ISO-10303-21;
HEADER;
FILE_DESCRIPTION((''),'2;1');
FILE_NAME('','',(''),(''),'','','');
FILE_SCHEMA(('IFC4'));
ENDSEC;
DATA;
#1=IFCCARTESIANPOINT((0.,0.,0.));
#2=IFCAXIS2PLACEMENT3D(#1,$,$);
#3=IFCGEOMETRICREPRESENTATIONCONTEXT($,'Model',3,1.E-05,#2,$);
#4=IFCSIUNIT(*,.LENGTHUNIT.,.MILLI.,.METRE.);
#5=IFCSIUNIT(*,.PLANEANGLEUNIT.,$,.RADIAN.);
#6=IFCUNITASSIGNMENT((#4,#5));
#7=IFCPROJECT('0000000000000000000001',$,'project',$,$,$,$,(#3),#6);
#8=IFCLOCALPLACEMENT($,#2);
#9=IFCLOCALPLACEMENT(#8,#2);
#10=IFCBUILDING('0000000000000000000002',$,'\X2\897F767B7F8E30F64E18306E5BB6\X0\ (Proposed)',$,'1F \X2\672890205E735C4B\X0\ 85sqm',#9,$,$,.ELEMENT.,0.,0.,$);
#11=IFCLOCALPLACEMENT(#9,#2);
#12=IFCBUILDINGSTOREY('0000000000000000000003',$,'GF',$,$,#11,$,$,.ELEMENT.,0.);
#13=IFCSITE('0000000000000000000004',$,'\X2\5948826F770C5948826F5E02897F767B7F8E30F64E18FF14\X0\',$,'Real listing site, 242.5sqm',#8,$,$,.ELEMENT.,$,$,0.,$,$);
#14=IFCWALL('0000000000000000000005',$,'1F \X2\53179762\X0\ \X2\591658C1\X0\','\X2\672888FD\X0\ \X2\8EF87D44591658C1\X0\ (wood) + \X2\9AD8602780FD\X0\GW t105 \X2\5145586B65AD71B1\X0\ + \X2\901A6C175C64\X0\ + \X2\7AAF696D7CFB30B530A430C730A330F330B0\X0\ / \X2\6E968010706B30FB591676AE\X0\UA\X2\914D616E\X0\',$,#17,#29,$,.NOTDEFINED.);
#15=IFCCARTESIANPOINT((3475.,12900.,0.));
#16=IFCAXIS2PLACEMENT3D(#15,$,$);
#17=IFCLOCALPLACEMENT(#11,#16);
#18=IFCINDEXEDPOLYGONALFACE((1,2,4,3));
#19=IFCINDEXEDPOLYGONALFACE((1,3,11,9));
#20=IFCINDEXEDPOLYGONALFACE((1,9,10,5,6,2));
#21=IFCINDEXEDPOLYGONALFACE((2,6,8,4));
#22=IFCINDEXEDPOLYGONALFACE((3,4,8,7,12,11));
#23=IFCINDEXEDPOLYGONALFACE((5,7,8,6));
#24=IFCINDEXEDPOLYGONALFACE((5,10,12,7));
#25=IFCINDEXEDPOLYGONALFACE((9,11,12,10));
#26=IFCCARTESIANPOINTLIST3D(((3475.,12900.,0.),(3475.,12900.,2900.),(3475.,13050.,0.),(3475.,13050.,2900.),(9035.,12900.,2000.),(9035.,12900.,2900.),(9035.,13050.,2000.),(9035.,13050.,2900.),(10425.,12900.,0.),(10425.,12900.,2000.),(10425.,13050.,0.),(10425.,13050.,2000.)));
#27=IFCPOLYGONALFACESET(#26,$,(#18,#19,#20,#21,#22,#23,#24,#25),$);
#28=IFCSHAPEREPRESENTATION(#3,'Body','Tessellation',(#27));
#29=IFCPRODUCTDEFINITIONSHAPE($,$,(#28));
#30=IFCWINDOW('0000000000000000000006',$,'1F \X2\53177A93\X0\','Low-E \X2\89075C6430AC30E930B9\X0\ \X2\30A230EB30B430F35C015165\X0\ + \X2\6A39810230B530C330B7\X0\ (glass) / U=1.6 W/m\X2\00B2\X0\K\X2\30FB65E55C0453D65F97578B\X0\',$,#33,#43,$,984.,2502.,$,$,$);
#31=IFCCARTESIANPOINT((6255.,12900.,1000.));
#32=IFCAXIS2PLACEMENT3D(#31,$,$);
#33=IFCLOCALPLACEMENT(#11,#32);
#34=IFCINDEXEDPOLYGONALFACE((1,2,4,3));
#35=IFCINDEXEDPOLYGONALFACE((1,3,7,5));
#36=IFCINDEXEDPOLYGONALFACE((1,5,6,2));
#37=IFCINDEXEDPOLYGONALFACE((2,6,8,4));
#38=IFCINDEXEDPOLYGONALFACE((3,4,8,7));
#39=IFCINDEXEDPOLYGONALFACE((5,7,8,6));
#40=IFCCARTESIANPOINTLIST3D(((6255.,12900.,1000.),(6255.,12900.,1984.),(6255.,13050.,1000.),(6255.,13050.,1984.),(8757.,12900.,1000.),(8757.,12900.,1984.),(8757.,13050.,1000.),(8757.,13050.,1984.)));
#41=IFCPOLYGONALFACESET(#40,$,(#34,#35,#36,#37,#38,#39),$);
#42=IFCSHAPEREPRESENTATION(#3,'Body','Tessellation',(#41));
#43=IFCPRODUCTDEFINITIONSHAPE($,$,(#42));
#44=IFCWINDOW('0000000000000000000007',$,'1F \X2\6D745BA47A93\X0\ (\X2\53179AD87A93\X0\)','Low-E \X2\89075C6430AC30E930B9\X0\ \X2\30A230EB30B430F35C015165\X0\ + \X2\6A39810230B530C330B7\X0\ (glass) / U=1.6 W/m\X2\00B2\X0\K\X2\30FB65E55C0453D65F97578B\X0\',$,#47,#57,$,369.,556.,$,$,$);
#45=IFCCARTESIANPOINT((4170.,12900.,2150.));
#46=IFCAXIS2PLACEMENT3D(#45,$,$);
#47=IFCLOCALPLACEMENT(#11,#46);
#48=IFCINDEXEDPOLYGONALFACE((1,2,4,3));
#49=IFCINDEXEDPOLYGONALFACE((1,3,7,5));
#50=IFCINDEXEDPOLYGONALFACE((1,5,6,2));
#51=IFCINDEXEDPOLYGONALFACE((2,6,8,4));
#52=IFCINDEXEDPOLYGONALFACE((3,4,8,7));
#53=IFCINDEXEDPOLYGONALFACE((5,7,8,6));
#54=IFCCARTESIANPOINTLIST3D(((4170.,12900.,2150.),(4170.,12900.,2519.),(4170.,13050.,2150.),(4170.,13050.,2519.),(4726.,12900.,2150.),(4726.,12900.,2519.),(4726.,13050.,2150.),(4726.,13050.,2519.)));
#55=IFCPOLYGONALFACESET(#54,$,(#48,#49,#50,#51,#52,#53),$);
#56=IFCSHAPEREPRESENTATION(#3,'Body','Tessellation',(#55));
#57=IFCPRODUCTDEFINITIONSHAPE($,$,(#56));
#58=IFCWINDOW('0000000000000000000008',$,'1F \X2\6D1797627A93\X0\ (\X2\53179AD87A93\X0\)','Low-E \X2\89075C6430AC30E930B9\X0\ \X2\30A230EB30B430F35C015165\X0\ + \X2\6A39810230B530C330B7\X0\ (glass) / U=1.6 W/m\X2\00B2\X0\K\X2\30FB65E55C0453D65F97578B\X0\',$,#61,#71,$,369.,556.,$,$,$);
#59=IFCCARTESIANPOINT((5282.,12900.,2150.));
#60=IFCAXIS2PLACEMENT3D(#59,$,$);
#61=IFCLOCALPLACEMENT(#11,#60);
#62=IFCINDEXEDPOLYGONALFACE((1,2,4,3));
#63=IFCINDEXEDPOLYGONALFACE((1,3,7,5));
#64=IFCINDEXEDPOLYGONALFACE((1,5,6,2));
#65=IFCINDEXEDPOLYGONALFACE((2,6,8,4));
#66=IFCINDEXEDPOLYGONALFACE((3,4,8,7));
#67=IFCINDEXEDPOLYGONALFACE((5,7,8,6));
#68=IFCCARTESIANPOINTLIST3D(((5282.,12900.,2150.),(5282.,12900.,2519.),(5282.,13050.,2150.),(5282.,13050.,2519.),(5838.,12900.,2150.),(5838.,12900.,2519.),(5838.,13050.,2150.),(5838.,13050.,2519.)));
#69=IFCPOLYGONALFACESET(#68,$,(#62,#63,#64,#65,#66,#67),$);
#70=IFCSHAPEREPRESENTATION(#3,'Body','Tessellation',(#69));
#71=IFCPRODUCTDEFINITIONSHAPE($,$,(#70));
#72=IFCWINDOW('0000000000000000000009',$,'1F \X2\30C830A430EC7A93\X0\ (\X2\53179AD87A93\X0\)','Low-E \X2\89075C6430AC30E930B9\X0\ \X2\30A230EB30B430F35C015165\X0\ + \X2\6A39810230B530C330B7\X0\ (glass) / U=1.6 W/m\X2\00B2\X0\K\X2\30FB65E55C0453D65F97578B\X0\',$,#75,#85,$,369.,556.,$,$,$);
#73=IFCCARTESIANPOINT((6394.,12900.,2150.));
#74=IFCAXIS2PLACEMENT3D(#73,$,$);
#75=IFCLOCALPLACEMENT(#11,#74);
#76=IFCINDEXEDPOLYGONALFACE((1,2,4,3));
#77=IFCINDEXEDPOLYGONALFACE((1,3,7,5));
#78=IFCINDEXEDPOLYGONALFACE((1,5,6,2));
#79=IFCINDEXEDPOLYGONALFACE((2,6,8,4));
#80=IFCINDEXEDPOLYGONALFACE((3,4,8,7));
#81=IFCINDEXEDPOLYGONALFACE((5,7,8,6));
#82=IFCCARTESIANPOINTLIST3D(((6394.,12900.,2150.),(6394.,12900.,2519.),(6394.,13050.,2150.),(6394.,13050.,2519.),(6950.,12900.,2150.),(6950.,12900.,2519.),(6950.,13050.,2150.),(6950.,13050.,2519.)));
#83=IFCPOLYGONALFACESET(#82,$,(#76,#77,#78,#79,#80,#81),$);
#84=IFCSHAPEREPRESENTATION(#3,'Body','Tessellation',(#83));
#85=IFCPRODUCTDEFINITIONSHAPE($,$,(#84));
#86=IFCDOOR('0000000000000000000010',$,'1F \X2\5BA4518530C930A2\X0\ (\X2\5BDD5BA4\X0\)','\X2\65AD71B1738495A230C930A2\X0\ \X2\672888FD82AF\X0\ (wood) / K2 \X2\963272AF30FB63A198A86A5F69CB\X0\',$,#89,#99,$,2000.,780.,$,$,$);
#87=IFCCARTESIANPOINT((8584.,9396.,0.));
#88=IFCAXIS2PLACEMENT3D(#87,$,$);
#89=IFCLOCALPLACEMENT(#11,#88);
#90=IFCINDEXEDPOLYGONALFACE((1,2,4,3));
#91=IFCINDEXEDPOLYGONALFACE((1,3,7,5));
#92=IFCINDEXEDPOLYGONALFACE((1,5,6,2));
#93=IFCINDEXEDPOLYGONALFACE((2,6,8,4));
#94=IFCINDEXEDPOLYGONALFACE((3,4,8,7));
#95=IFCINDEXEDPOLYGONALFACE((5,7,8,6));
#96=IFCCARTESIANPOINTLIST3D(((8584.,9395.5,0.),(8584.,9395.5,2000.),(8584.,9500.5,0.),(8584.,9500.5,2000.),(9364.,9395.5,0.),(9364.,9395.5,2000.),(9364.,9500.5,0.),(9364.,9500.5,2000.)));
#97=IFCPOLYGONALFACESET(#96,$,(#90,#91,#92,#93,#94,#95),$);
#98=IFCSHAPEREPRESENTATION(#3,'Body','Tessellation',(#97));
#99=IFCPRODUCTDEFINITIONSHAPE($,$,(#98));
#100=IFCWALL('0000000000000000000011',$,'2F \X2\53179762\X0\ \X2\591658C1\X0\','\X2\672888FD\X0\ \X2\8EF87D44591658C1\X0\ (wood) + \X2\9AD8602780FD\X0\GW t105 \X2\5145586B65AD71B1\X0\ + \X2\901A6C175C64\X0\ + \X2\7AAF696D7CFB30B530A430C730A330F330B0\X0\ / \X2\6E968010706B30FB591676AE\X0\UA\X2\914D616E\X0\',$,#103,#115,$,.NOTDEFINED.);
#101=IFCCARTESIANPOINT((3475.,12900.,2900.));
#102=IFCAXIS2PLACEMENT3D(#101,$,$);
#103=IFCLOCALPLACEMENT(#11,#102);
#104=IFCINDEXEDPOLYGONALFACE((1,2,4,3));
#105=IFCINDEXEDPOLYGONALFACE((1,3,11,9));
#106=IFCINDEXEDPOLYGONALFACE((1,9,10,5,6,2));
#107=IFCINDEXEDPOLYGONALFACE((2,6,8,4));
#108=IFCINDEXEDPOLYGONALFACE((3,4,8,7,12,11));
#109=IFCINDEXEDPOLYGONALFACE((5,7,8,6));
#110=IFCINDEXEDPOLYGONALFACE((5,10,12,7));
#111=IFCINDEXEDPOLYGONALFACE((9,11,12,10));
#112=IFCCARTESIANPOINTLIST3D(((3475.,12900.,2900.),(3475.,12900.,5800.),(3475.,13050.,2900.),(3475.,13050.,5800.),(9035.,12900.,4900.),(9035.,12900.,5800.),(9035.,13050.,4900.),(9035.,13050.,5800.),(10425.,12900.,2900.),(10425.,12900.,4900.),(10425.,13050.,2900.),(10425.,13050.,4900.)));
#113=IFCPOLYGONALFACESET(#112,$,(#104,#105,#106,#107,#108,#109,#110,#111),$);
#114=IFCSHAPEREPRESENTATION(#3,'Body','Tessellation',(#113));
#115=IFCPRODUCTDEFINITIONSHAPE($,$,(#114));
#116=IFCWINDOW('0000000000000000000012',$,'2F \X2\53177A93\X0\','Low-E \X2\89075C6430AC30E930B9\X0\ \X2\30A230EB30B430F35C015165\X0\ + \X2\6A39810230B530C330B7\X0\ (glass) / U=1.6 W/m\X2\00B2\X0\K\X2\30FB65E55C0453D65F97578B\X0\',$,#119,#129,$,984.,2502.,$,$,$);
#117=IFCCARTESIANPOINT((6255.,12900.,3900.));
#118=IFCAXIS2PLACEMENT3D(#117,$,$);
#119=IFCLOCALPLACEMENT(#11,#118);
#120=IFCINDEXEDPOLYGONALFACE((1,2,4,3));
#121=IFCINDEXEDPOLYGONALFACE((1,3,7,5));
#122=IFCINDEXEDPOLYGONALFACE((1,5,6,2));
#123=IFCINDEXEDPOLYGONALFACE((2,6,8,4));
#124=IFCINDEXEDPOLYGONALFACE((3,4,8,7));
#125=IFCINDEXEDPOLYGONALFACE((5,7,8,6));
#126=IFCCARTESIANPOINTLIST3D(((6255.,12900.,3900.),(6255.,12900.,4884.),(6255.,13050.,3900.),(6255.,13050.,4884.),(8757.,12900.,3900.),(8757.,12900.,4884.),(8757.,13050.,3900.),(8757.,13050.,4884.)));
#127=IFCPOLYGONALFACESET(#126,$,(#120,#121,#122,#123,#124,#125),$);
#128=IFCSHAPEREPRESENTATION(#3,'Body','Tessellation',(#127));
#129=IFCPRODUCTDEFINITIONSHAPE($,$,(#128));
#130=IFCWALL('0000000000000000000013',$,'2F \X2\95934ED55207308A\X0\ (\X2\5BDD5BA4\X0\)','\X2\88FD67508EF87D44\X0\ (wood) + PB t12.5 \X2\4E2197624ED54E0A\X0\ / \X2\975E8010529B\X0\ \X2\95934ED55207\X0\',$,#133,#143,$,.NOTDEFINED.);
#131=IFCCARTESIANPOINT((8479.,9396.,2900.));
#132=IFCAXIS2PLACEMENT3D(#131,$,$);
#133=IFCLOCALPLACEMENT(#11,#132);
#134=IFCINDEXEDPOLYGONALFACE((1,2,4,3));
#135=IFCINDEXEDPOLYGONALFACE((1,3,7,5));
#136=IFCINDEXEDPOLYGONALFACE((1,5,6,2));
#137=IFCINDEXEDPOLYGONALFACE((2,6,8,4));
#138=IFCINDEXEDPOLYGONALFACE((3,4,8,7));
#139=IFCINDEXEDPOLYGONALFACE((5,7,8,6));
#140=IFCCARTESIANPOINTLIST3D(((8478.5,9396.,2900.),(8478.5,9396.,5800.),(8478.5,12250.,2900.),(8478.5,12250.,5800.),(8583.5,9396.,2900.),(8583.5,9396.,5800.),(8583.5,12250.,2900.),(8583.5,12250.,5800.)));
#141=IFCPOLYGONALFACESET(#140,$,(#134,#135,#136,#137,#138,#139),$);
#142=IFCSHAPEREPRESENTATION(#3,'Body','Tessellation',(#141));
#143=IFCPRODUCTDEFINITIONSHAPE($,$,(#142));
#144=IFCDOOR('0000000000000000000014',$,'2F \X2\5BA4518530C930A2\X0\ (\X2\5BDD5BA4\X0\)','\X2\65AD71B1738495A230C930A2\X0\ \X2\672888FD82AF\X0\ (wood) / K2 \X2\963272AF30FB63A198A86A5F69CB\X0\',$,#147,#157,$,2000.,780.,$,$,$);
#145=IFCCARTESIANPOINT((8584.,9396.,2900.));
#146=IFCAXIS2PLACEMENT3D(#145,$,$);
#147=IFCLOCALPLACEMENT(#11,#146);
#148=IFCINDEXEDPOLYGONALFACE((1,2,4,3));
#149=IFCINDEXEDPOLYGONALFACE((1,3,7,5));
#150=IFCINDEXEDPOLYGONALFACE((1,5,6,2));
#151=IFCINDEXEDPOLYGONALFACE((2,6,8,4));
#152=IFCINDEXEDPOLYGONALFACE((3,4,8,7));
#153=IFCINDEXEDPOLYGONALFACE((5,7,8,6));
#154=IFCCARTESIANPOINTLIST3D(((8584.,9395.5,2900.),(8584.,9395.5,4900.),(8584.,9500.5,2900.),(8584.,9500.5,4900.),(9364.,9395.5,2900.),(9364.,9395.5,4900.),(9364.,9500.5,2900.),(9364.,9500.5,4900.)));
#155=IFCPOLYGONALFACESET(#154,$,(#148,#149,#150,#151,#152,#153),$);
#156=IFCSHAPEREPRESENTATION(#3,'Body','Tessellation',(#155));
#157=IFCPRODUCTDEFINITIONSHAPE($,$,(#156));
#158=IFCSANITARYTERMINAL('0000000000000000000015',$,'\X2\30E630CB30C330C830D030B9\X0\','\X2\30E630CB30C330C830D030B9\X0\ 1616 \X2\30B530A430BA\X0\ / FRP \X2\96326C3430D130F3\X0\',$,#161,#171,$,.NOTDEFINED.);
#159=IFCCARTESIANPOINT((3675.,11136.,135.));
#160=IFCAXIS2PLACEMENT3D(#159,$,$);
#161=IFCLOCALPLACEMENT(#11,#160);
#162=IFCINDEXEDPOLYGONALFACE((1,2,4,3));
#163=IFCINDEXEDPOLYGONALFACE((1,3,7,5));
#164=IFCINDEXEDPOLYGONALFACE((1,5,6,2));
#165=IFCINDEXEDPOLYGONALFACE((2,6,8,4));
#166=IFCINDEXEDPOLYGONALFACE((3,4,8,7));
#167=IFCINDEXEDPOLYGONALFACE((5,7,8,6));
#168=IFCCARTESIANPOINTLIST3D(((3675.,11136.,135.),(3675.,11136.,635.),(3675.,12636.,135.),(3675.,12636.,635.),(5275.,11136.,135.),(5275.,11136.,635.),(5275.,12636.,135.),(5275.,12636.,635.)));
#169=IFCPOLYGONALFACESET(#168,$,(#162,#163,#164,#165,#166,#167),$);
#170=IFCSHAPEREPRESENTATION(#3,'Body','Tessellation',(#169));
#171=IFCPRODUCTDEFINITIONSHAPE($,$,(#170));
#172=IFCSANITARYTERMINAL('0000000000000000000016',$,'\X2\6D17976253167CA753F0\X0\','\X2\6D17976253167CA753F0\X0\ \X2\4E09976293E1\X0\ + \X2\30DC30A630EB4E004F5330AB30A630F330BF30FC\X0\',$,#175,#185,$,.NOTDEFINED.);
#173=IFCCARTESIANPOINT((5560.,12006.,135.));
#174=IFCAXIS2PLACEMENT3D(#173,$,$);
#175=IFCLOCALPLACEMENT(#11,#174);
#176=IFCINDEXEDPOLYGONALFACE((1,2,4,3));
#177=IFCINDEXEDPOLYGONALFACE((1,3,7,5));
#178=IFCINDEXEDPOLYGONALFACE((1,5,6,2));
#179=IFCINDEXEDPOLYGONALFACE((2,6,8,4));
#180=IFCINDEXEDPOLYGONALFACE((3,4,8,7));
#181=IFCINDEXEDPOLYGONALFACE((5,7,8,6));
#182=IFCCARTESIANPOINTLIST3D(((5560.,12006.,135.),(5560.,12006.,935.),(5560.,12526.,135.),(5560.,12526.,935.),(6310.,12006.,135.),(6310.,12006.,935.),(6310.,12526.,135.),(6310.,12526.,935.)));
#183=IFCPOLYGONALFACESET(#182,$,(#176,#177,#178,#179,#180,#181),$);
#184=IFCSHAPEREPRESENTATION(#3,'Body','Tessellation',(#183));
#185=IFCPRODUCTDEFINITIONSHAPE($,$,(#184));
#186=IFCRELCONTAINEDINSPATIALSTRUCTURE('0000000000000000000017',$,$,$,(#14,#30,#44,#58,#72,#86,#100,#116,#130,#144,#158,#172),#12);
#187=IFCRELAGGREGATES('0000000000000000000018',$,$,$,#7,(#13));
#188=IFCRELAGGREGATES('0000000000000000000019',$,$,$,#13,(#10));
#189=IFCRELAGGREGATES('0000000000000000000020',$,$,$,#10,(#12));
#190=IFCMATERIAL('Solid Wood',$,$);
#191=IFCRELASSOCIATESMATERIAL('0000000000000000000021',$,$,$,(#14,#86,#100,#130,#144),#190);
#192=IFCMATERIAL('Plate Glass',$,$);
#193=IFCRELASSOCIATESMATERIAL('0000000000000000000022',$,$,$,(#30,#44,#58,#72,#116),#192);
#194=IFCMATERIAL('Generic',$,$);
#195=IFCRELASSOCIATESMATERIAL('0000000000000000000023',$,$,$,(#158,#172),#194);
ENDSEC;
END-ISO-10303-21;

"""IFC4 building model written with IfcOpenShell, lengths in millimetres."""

from ifc_helpers import new_model, si_unit, frame, frame_2d, origin, place, context, project, spatial, rectangle, extrude, material, element, fill, save


model = new_model("IFC4")

# Units and contexts
model_context = context("Model", 3, precision=1e-05, world=origin())
ifc_project = project(units=[si_unit("LENGTHUNIT", "METRE", prefix="MILLI"), si_unit("PLANEANGLEUNIT", "RADIAN")], contexts=[model_context])

# Site, building, storey
site_placement = place(None, origin())
site = spatial("IfcSite", under=ifc_project, at=site_placement, Name="奈良県奈良市西登美ヶ丘４", ObjectType="Real listing site, 242.5sqm", CompositionType="ELEMENT", RefElevation=0.0)
building_placement = place(site_placement, origin())
building = spatial("IfcBuilding", under=site, at=building_placement, Name="西登美ヶ丘の家 (Proposed)", ObjectType="1F 木造平屋 85sqm", CompositionType="ELEMENT", ElevationOfRefHeight=0.0, ElevationOfTerrain=0.0)
storey_placement = place(building_placement, origin())
storey = spatial("IfcBuildingStorey", under=building, at=storey_placement, Name="GF", CompositionType="ELEMENT", Elevation=0.0)

# Wall, openings, windows
ifc_material_1 = material(Name="Solid Wood")
wall_1_placement = place(storey_placement, frame((3475.0, 12900.0, 0.0)))
wall_1 = element("IfcWall", 1, at=wall_1_placement, inside=storey, material=ifc_material_1, Name="1F 北面 外壁", Description="木製 軸組外壁 (wood) + 高性能GW t105 充填断熱 + 通気層 + 窯業系サイディング / 準耐火・外皮UA配慮", PredefinedType="NOTDEFINED", context=model_context, shape_type="SweptSolid", body=[
    extrude(rectangle(XDim=6950.0, YDim=150.0, at=frame_2d((3475.0, 75.0))), frame((3475.0, 12900.0, 0.0)), (0.0, 0.0, 1.0), 2900.0),
])
opening_1_placement = place(storey_placement, frame((6255.0, 12900.0, 1000.0)))
opening_1 = element("IfcOpeningElement", 2, at=opening_1_placement, cuts=wall_1, PredefinedType="NOTDEFINED", context=model_context, shape_type="SweptSolid", body=[
    extrude(rectangle(XDim=2502.0, YDim=150.0, at=frame_2d((1251.0, 75.0))), frame((6255.0, 12900.0, 1000.0)), (0.0, 0.0, 1.0), 984.0),
])
opening_2_placement = place(storey_placement, frame((4170.0, 12900.0, 2150.0)))
opening_2 = element("IfcOpeningElement", 3, at=opening_2_placement, cuts=wall_1, PredefinedType="NOTDEFINED", context=model_context, shape_type="SweptSolid", body=[
    extrude(rectangle(XDim=556.0, YDim=150.0, at=frame_2d((278.0, 75.0))), frame((4170.0, 12900.0, 2150.0)), (0.0, 0.0, 1.0), 369.0),
])
opening_3_placement = place(storey_placement, frame((5282.0, 12900.0, 2150.0)))
opening_3 = element("IfcOpeningElement", 4, at=opening_3_placement, cuts=wall_1, PredefinedType="NOTDEFINED", context=model_context, shape_type="SweptSolid", body=[
    extrude(rectangle(XDim=556.0, YDim=150.0, at=frame_2d((278.0, 75.0))), frame((5282.0, 12900.0, 2150.0)), (0.0, 0.0, 1.0), 369.0),
])
opening_4_placement = place(storey_placement, frame((6394.0, 12900.0, 2150.0)))
opening_4 = element("IfcOpeningElement", 5, at=opening_4_placement, cuts=wall_1, PredefinedType="NOTDEFINED", context=model_context, shape_type="SweptSolid", body=[
    extrude(rectangle(XDim=556.0, YDim=150.0, at=frame_2d((278.0, 75.0))), frame((6394.0, 12900.0, 2150.0)), (0.0, 0.0, 1.0), 369.0),
])
ifc_material_2 = material(Name="Plate Glass")
window_1_placement = place(storey_placement, frame((6255.0, 12900.0, 1000.0)))
window_1 = element("IfcWindow", 6, at=window_1_placement, inside=storey, material=ifc_material_2, Name="1F 北窓", Description="Low-E 複層ガラス アルゴン封入 + 樹脂サッシ (glass) / U=1.6 W/m²K・日射取得型", OverallHeight=984.0, OverallWidth=2502.0, context=model_context, shape_type="SweptSolid", body=[
    extrude(rectangle(XDim=2502.0, YDim=150.0, at=frame_2d((1251.0, 75.0))), frame((6255.0, 12900.0, 1000.0)), (0.0, 0.0, 1.0), 984.0),
])
fill(opening_1, window_1)
window_2_placement = place(storey_placement, frame((4170.0, 12900.0, 2150.0)))
window_2 = element("IfcWindow", 7, at=window_2_placement, inside=storey, material=ifc_material_2, Name="1F 浴室窓 (北高窓)", Description="Low-E 複層ガラス アルゴン封入 + 樹脂サッシ (glass) / U=1.6 W/m²K・日射取得型", OverallHeight=369.0, OverallWidth=556.0, context=model_context, shape_type="SweptSolid", body=[
    extrude(rectangle(XDim=556.0, YDim=150.0, at=frame_2d((278.0, 75.0))), frame((4170.0, 12900.0, 2150.0)), (0.0, 0.0, 1.0), 369.0),
])
fill(opening_2, window_2)
window_3_placement = place(storey_placement, frame((5282.0, 12900.0, 2150.0)))
window_3 = element("IfcWindow", 8, at=window_3_placement, inside=storey, material=ifc_material_2, Name="1F 洗面窓 (北高窓)", Description="Low-E 複層ガラス アルゴン封入 + 樹脂サッシ (glass) / U=1.6 W/m²K・日射取得型", OverallHeight=369.0, OverallWidth=556.0, context=model_context, shape_type="SweptSolid", body=[
    extrude(rectangle(XDim=556.0, YDim=150.0, at=frame_2d((278.0, 75.0))), frame((5282.0, 12900.0, 2150.0)), (0.0, 0.0, 1.0), 369.0),
])
fill(opening_3, window_3)
window_4_placement = place(storey_placement, frame((6394.0, 12900.0, 2150.0)))
window_4 = element("IfcWindow", 9, at=window_4_placement, inside=storey, material=ifc_material_2, Name="1F トイレ窓 (北高窓)", Description="Low-E 複層ガラス アルゴン封入 + 樹脂サッシ (glass) / U=1.6 W/m²K・日射取得型", OverallHeight=369.0, OverallWidth=556.0, context=model_context, shape_type="SweptSolid", body=[
    extrude(rectangle(XDim=556.0, YDim=150.0, at=frame_2d((278.0, 75.0))), frame((6394.0, 12900.0, 2150.0)), (0.0, 0.0, 1.0), 369.0),
])
fill(opening_4, window_4)

# Door
door_1_placement = place(storey_placement, frame((8584.0, 9396.0, 0.0)))
element("IfcDoor", 10, at=door_1_placement, inside=storey, material=ifc_material_1, Name="1F 室内ドア (寝室)", Description="断熱玄関ドア 木製芯 (wood) / K2 防犯・採風機構", OverallHeight=2000.0, OverallWidth=780.0, context=model_context, shape_type="SweptSolid", body=[
    extrude(rectangle(XDim=780.0, YDim=105.0, at=frame_2d((390.0, 52.0))), frame((8584.0, 9396.0, 0.0)), (0.0, 0.0, 1.0), 2000.0),
])

# Wall, opening, window
wall_2_placement = place(storey_placement, frame((3475.0, 12900.0, 2900.0)))
wall_2 = element("IfcWall", 11, at=wall_2_placement, inside=storey, material=ifc_material_1, Name="2F 北面 外壁", Description="木製 軸組外壁 (wood) + 高性能GW t105 充填断熱 + 通気層 + 窯業系サイディング / 準耐火・外皮UA配慮", PredefinedType="NOTDEFINED", context=model_context, shape_type="SweptSolid", body=[
    extrude(rectangle(XDim=6950.0, YDim=150.0, at=frame_2d((3475.0, 75.0))), frame((3475.0, 12900.0, 2900.0)), (0.0, 0.0, 1.0), 2900.0),
])
opening_5_placement = place(storey_placement, frame((6255.0, 12900.0, 3900.0)))
opening_5 = element("IfcOpeningElement", 12, at=opening_5_placement, cuts=wall_2, PredefinedType="NOTDEFINED", context=model_context, shape_type="SweptSolid", body=[
    extrude(rectangle(XDim=2502.0, YDim=150.0, at=frame_2d((1251.0, 75.0))), frame((6255.0, 12900.0, 3900.0)), (0.0, 0.0, 1.0), 984.0),
])
window_5_placement = place(storey_placement, frame((6255.0, 12900.0, 3900.0)))
window_5 = element("IfcWindow", 13, at=window_5_placement, inside=storey, material=ifc_material_2, Name="2F 北窓", Description="Low-E 複層ガラス アルゴン封入 + 樹脂サッシ (glass) / U=1.6 W/m²K・日射取得型", OverallHeight=984.0, OverallWidth=2502.0, context=model_context, shape_type="SweptSolid", body=[
    extrude(rectangle(XDim=2502.0, YDim=150.0, at=frame_2d((1251.0, 75.0))), frame((6255.0, 12900.0, 3900.0)), (0.0, 0.0, 1.0), 984.0),
])
fill(opening_5, window_5)

# Wall
wall_3_placement = place(storey_placement, frame((8479.0, 9396.0, 2900.0)))
element("IfcWall", 14, at=wall_3_placement, inside=storey, material=ifc_material_1, Name="2F 間仕切り (寝室)", Description="製材軸組 (wood) + PB t12.5 両面仕上 / 非耐力 間仕切", PredefinedType="NOTDEFINED", context=model_context, shape_type="SweptSolid", body=[
    extrude(rectangle(XDim=105.0, YDim=2854.0, at=frame_2d((52.0, 1427.0))), frame((8479.0, 9396.0, 2900.0)), (0.0, 0.0, 1.0), 2900.0),
])

# Door
door_2_placement = place(storey_placement, frame((8584.0, 9396.0, 2900.0)))
element("IfcDoor", 15, at=door_2_placement, inside=storey, material=ifc_material_1, Name="2F 室内ドア (寝室)", Description="断熱玄関ドア 木製芯 (wood) / K2 防犯・採風機構", OverallHeight=2000.0, OverallWidth=780.0, context=model_context, shape_type="SweptSolid", body=[
    extrude(rectangle(XDim=780.0, YDim=105.0, at=frame_2d((390.0, 52.0))), frame((8584.0, 9396.0, 2900.0)), (0.0, 0.0, 1.0), 2000.0),
])

# Sanitary terminals
ifc_material_3 = material(Name="Generic")
sanitary_terminal_1_placement = place(storey_placement, frame((3675.0, 11136.0, 135.0)))
element("IfcSanitaryTerminal", 16, at=sanitary_terminal_1_placement, inside=storey, material=ifc_material_3, Name="ユニットバス", Description="ユニットバス 1616 サイズ / FRP 防水パン", PredefinedType="NOTDEFINED", context=model_context, shape_type="SweptSolid", body=[
    extrude(rectangle(XDim=1600.0, YDim=1500.0, at=frame_2d((800.0, 750.0))), frame((3675.0, 11136.0, 135.0)), (0.0, 0.0, 1.0), 500.0),
])
sanitary_terminal_2_placement = place(storey_placement, frame((5560.0, 12006.0, 135.0)))
element("IfcSanitaryTerminal", 17, at=sanitary_terminal_2_placement, inside=storey, material=ifc_material_3, Name="洗面化粧台", Description="洗面化粧台 三面鏡 + ボウル一体カウンター", PredefinedType="NOTDEFINED", context=model_context, shape_type="SweptSolid", body=[
    extrude(rectangle(XDim=750.0, YDim=520.0, at=frame_2d((375.0, 260.0))), frame((5560.0, 12006.0, 135.0)), (0.0, 0.0, 1.0), 800.0),
])

save(model, "model.ifc")
